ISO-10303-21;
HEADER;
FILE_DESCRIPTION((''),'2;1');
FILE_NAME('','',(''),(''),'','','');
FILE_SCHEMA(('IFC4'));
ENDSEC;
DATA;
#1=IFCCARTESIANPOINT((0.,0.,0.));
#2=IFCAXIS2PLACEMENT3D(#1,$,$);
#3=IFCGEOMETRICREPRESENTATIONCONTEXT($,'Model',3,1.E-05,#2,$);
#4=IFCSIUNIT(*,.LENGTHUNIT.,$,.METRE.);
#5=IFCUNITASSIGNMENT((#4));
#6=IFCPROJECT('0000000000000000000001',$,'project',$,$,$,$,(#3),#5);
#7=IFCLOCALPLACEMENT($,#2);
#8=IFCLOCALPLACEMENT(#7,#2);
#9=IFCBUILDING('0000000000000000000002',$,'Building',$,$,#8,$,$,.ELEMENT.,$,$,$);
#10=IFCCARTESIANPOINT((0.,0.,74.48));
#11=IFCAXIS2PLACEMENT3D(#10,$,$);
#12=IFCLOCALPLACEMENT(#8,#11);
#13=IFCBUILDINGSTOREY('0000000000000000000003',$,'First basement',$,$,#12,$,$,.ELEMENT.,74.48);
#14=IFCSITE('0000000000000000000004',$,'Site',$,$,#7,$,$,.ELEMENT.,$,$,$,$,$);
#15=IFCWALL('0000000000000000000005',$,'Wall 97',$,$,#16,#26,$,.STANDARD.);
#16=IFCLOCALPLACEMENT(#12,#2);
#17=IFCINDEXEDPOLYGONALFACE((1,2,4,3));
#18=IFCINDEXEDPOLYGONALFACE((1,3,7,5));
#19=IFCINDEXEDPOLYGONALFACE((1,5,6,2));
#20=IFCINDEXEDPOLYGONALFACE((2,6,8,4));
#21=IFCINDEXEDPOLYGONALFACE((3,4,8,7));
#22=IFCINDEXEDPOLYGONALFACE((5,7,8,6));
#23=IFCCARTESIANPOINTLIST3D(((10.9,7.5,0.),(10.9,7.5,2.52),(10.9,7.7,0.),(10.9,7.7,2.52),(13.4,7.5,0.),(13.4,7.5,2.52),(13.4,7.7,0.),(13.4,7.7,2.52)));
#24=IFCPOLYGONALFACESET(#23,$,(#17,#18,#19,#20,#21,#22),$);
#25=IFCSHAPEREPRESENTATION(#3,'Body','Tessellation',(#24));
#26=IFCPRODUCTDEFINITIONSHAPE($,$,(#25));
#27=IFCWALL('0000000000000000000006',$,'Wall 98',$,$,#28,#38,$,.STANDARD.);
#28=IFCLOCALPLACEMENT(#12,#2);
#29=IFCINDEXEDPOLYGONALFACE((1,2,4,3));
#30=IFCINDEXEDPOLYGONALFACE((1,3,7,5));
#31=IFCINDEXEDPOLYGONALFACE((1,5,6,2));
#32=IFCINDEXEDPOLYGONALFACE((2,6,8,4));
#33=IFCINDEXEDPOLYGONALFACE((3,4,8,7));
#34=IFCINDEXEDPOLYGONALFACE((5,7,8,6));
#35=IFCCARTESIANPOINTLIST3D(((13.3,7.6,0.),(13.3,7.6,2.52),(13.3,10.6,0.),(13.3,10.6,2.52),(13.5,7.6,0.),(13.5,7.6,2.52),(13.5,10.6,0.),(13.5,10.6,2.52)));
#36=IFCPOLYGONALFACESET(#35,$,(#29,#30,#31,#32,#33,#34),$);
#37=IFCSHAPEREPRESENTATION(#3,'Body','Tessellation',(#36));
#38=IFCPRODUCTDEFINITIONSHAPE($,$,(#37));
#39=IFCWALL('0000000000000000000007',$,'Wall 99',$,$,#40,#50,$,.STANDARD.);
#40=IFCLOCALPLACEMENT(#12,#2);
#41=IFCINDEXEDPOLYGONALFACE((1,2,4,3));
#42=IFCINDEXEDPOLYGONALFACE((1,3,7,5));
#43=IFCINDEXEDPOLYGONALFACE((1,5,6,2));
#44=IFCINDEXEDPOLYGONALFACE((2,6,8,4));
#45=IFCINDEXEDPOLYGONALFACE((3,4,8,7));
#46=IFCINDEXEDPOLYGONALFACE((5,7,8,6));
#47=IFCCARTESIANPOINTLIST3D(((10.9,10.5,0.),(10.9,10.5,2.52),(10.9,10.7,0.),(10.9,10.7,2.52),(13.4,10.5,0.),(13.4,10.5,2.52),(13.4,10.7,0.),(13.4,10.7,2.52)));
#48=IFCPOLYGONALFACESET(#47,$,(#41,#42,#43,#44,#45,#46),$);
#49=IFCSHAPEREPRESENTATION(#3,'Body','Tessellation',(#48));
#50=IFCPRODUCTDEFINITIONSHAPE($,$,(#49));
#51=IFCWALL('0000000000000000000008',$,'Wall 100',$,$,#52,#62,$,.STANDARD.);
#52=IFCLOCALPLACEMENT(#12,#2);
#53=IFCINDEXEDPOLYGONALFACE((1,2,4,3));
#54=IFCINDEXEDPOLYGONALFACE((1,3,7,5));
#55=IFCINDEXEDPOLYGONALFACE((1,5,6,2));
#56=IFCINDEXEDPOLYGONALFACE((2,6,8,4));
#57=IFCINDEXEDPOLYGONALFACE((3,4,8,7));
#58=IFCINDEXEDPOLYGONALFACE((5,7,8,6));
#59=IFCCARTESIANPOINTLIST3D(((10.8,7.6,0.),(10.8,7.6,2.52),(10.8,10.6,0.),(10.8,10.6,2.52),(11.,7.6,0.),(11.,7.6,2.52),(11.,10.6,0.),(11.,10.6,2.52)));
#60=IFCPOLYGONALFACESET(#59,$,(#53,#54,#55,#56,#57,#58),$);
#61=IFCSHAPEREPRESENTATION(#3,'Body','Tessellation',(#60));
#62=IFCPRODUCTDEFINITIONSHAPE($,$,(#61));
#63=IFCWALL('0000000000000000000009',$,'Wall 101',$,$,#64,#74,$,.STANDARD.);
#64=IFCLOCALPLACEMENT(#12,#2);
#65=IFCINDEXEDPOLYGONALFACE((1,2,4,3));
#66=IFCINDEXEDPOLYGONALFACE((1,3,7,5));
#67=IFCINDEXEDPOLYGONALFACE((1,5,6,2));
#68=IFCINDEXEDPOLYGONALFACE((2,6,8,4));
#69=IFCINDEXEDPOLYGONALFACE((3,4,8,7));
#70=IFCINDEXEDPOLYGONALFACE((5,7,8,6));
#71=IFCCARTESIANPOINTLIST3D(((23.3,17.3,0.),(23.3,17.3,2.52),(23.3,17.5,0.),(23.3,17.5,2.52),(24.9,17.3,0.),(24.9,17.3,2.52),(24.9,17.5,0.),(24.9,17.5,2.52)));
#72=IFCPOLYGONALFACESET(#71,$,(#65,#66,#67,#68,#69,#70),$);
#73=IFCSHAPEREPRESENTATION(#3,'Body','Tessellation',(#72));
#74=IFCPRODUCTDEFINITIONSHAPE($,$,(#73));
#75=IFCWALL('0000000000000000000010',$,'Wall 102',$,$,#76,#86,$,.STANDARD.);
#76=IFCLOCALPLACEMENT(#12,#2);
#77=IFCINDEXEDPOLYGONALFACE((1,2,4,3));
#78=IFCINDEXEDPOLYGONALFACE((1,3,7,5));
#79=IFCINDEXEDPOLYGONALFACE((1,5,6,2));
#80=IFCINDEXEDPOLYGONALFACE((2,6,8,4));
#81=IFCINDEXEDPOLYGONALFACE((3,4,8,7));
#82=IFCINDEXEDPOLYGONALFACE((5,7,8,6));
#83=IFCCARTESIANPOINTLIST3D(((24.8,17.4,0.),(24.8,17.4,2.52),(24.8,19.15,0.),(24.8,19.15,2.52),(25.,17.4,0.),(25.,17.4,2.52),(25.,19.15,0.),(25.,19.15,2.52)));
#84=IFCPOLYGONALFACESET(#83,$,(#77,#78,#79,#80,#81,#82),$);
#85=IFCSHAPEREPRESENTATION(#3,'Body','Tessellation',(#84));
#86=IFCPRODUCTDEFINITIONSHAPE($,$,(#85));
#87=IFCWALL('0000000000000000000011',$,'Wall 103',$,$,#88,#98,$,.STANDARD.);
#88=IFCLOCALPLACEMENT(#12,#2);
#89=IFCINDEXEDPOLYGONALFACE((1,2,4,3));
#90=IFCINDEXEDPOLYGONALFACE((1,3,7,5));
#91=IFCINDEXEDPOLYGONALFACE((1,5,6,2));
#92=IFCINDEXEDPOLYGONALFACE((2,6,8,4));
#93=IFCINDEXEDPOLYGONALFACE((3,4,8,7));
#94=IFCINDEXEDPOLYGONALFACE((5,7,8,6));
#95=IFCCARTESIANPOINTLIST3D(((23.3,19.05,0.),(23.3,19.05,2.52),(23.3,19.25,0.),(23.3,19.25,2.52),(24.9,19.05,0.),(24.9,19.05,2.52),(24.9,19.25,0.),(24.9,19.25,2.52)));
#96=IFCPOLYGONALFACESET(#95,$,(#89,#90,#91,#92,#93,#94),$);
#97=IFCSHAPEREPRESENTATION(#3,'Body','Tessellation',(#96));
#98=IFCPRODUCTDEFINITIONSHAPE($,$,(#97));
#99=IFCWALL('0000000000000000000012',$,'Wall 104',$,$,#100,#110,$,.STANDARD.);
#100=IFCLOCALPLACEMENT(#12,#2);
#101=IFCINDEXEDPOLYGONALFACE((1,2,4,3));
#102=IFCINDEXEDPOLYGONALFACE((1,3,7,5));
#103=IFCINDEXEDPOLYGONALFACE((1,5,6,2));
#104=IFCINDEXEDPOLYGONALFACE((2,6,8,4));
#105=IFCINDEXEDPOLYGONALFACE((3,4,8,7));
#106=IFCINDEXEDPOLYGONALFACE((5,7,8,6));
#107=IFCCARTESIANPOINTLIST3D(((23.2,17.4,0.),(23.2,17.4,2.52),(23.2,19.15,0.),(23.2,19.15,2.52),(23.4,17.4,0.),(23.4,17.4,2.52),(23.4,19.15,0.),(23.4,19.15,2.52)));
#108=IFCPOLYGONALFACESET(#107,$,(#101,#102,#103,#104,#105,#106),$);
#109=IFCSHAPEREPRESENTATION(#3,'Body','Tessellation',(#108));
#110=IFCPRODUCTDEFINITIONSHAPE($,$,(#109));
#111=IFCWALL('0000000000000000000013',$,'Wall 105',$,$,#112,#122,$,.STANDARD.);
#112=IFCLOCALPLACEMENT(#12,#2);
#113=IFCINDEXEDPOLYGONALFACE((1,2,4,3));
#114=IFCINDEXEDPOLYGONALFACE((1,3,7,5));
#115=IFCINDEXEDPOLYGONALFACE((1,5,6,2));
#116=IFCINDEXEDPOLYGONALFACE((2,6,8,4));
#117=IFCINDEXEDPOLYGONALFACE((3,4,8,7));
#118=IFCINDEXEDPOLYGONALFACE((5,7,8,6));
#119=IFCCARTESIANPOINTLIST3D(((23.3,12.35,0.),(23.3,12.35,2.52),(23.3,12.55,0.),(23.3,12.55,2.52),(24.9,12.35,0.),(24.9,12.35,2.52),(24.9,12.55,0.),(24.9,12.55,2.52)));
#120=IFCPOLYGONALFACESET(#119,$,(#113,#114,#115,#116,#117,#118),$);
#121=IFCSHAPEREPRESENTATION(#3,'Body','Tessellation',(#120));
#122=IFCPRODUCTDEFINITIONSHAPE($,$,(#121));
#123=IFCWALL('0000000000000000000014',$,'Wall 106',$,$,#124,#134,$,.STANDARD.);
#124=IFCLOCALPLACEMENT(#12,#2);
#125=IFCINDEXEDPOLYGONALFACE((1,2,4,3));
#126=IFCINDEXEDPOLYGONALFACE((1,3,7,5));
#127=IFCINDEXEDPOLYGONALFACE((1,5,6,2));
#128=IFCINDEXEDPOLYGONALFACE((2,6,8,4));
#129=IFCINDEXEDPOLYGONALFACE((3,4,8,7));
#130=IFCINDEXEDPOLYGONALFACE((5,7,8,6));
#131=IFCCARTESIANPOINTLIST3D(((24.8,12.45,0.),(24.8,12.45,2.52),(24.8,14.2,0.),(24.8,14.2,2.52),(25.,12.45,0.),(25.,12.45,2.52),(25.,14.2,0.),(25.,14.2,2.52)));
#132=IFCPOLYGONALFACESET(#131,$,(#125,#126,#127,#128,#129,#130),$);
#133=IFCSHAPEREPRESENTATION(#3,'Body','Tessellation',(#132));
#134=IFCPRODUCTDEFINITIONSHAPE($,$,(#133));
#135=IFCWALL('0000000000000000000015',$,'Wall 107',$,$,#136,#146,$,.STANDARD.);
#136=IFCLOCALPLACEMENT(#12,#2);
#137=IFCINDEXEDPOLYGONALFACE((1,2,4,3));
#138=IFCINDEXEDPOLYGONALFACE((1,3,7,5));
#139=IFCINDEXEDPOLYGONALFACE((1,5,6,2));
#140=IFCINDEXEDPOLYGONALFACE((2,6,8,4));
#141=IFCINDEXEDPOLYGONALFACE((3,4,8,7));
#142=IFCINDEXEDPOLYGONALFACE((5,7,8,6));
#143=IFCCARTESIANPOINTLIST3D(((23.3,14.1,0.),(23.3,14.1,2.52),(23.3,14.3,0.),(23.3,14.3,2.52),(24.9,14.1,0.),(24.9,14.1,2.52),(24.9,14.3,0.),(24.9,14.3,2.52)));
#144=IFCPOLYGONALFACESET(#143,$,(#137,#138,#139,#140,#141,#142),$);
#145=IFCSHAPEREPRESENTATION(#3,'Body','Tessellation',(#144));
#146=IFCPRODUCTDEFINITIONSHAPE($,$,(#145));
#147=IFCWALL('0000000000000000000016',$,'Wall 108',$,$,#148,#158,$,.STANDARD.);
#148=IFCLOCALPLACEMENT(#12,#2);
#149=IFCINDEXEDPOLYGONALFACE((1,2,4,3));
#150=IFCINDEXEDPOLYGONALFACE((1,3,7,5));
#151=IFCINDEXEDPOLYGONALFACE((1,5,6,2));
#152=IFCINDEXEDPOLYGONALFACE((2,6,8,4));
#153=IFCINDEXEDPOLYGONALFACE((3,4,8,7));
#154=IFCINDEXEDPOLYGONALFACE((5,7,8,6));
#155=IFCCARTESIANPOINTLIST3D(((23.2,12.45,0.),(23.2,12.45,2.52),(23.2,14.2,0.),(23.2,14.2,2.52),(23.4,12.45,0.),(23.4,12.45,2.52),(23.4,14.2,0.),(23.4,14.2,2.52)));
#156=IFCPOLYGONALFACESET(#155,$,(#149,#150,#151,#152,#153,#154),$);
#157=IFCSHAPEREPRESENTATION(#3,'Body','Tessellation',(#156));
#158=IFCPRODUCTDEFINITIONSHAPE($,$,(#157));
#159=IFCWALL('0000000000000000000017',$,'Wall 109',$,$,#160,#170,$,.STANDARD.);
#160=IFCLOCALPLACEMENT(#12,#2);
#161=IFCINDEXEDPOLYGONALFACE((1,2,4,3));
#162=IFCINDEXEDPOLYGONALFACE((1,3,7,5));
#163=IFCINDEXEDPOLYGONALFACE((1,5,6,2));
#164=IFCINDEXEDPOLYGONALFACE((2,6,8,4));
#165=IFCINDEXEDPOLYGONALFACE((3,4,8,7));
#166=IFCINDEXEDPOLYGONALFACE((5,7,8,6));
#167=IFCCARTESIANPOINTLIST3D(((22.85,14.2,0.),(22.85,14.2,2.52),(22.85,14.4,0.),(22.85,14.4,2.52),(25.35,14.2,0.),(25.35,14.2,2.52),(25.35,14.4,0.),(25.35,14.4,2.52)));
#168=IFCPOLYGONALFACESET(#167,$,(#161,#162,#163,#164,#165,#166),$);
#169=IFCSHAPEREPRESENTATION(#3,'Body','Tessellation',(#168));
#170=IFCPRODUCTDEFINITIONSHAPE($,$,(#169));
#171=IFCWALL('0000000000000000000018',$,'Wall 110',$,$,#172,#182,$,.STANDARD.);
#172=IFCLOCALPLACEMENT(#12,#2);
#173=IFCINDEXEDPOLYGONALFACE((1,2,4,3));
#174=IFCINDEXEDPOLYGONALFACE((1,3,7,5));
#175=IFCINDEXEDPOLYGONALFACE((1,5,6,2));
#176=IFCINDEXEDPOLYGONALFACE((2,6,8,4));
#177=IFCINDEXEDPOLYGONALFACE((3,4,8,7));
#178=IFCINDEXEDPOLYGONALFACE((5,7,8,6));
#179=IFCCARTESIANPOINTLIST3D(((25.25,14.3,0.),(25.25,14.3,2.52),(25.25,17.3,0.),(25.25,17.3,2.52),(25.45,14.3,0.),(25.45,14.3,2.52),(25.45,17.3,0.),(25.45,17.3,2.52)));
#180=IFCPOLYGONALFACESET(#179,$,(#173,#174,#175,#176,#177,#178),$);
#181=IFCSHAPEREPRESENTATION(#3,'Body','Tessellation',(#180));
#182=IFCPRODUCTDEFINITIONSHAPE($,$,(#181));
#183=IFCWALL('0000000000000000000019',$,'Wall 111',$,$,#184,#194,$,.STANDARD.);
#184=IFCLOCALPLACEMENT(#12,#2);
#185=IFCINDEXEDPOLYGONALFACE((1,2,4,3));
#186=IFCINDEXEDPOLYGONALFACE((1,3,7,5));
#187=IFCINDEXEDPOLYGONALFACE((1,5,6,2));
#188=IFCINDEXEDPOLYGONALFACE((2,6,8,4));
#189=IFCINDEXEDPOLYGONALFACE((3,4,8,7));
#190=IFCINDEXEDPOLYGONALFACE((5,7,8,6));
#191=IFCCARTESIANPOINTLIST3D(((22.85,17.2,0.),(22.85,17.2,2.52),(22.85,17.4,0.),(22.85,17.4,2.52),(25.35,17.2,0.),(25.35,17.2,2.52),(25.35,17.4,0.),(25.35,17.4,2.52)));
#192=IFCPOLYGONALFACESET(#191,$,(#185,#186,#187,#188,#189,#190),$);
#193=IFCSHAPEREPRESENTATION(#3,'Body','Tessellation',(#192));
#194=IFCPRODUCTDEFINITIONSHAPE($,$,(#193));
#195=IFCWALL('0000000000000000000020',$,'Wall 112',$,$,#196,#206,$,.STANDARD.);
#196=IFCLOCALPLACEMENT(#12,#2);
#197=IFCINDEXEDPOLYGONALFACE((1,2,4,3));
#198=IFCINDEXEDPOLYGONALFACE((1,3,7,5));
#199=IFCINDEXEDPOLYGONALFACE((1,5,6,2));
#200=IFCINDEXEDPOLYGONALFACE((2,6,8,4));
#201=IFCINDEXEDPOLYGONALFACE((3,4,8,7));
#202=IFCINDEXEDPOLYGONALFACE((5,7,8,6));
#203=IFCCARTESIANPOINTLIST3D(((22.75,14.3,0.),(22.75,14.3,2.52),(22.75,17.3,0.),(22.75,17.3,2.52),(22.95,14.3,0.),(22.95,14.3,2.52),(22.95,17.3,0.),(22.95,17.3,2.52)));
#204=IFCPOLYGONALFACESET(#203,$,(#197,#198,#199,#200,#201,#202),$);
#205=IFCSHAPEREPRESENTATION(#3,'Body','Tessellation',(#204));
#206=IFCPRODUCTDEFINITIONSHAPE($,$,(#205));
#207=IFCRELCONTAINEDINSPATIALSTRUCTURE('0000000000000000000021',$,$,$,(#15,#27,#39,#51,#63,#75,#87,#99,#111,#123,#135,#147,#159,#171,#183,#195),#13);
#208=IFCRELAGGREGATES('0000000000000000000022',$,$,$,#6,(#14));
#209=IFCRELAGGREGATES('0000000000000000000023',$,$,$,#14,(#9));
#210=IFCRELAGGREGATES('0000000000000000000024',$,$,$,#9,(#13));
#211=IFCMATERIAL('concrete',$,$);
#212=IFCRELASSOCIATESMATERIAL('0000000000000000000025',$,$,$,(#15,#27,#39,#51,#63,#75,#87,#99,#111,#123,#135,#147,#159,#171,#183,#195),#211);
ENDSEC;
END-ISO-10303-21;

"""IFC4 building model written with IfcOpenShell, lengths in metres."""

from ifc_helpers import new_model, si_unit, frame, frame_2d, origin, place, context, project, spatial, rectangle, extrude, material, element, save


model = new_model("IFC4")

# Units and contexts
model_context = context("Model", 3, precision=1e-05, world=origin())
ifc_project = project(units=[si_unit("LENGTHUNIT", "METRE")], contexts=[model_context])

# Site, building, storey
site_placement = place(None, origin())
site = spatial("IfcSite", under=ifc_project, at=site_placement, Name="Site", CompositionType="ELEMENT")
building_placement = place(site_placement, origin())
building = spatial("IfcBuilding", under=site, at=building_placement, Name="Building", CompositionType="ELEMENT")
storey_placement = place(building_placement, frame((0.0, 0.0, 74.48)))
storey = spatial("IfcBuildingStorey", under=building, at=storey_placement, Name="First basement", CompositionType="ELEMENT", Elevation=74.48)

# Shared definitions
ifc_material = material(Name="concrete")

# Walls
wall_1_placement = place(storey_placement, frame((10.9, 7.6, 0.0), z_axis=(0.0, 0.0, 1.0), x_axis=(1.0, 0.0, 0.0)))
element("IfcWall", 1, at=wall_1_placement, inside=storey, material=ifc_material, Name="Wall 97", PredefinedType="STANDARD", context=model_context, shape_type="SweptSolid", body=[
    extrude(rectangle(XDim=2.5, YDim=0.2, at=frame_2d((1.25, 0.0))), origin(), (0.0, 0.0, 1.0), 2.52),
])
wall_2_placement = place(storey_placement, frame((13.4, 7.6, 0.0), z_axis=(0.0, 0.0, 1.0), x_axis=(0.0, 1.0, 0.0)))
element("IfcWall", 2, at=wall_2_placement, inside=storey, material=ifc_material, Name="Wall 98", PredefinedType="STANDARD", context=model_context, shape_type="SweptSolid", body=[
    extrude(rectangle(XDim=3.0, YDim=0.2, at=frame_2d((1.5, 0.0))), origin(), (0.0, 0.0, 1.0), 2.52),
])
wall_3_placement = place(storey_placement, frame((13.4, 10.6, 0.0), z_axis=(0.0, 0.0, 1.0), x_axis=(-1.0, 0.0, 0.0)))
element("IfcWall", 3, at=wall_3_placement, inside=storey, material=ifc_material, Name="Wall 99", PredefinedType="STANDARD", context=model_context, shape_type="SweptSolid", body=[
    extrude(rectangle(XDim=2.5, YDim=0.2, at=frame_2d((1.25, 0.0))), origin(), (0.0, 0.0, 1.0), 2.52),
])
wall_4_placement = place(storey_placement, frame((10.9, 10.6, 0.0), z_axis=(0.0, 0.0, 1.0), x_axis=(0.0, -1.0, 0.0)))
element("IfcWall", 4, at=wall_4_placement, inside=storey, material=ifc_material, Name="Wall 100", PredefinedType="STANDARD", context=model_context, shape_type="SweptSolid", body=[
    extrude(rectangle(XDim=3.0, YDim=0.2, at=frame_2d((1.5, 0.0))), origin(), (0.0, 0.0, 1.0), 2.52),
])
wall_5_placement = place(storey_placement, frame((23.3, 17.4, 0.0), z_axis=(0.0, 0.0, 1.0), x_axis=(1.0, 0.0, 0.0)))
element("IfcWall", 5, at=wall_5_placement, inside=storey, material=ifc_material, Name="Wall 101", PredefinedType="STANDARD", context=model_context, shape_type="SweptSolid", body=[
    extrude(rectangle(XDim=1.6, YDim=0.2, at=frame_2d((0.8, 0.0))), origin(), (0.0, 0.0, 1.0), 2.52),
])
wall_6_placement = place(storey_placement, frame((24.9, 17.4, 0.0), z_axis=(0.0, 0.0, 1.0), x_axis=(0.0, 1.0, 0.0)))
element("IfcWall", 6, at=wall_6_placement, inside=storey, material=ifc_material, Name="Wall 102", PredefinedType="STANDARD", context=model_context, shape_type="SweptSolid", body=[
    extrude(rectangle(XDim=1.75, YDim=0.2, at=frame_2d((0.875, 0.0))), origin(), (0.0, 0.0, 1.0), 2.52),
])
wall_7_placement = place(storey_placement, frame((24.9, 19.15, 0.0), z_axis=(0.0, 0.0, 1.0), x_axis=(-1.0, 0.0, 0.0)))
element("IfcWall", 7, at=wall_7_placement, inside=storey, material=ifc_material, Name="Wall 103", PredefinedType="STANDARD", context=model_context, shape_type="SweptSolid", body=[
    extrude(rectangle(XDim=1.6, YDim=0.2, at=frame_2d((0.8, 0.0))), origin(), (0.0, 0.0, 1.0), 2.52),
])
wall_8_placement = place(storey_placement, frame((23.3, 19.15, 0.0), z_axis=(0.0, 0.0, 1.0), x_axis=(0.0, -1.0, 0.0)))
element("IfcWall", 8, at=wall_8_placement, inside=storey, material=ifc_material, Name="Wall 104", PredefinedType="STANDARD", context=model_context, shape_type="SweptSolid", body=[
    extrude(rectangle(XDim=1.75, YDim=0.2, at=frame_2d((0.875, 0.0))), origin(), (0.0, 0.0, 1.0), 2.52),
])
wall_9_placement = place(storey_placement, frame((23.3, 12.45, 0.0), z_axis=(0.0, 0.0, 1.0), x_axis=(1.0, 0.0, 0.0)))
element("IfcWall", 9, at=wall_9_placement, inside=storey, material=ifc_material, Name="Wall 105", PredefinedType="STANDARD", context=model_context, shape_type="SweptSolid", body=[
    extrude(rectangle(XDim=1.6, YDim=0.2, at=frame_2d((0.8, 0.0))), origin(), (0.0, 0.0, 1.0), 2.52),
])
wall_10_placement = place(storey_placement, frame((24.9, 12.45, 0.0), z_axis=(0.0, 0.0, 1.0), x_axis=(0.0, 1.0, 0.0)))
element("IfcWall", 10, at=wall_10_placement, inside=storey, material=ifc_material, Name="Wall 106", PredefinedType="STANDARD", context=model_context, shape_type="SweptSolid", body=[
    extrude(rectangle(XDim=1.75, YDim=0.2, at=frame_2d((0.875, 0.0))), origin(), (0.0, 0.0, 1.0), 2.52),
])
wall_11_placement = place(storey_placement, frame((24.9, 14.2, 0.0), z_axis=(0.0, 0.0, 1.0), x_axis=(-1.0, 0.0, 0.0)))
element("IfcWall", 11, at=wall_11_placement, inside=storey, material=ifc_material, Name="Wall 107", PredefinedType="STANDARD", context=model_context, shape_type="SweptSolid", body=[
    extrude(rectangle(XDim=1.6, YDim=0.2, at=frame_2d((0.8, 0.0))), origin(), (0.0, 0.0, 1.0), 2.52),
])
wall_12_placement = place(storey_placement, frame((23.3, 14.2, 0.0), z_axis=(0.0, 0.0, 1.0), x_axis=(0.0, -1.0, 0.0)))
element("IfcWall", 12, at=wall_12_placement, inside=storey, material=ifc_material, Name="Wall 108", PredefinedType="STANDARD", context=model_context, shape_type="SweptSolid", body=[
    extrude(rectangle(XDim=1.75, YDim=0.2, at=frame_2d((0.875, 0.0))), origin(), (0.0, 0.0, 1.0), 2.52),
])
wall_13_placement = place(storey_placement, frame((22.85, 14.3, 0.0), z_axis=(0.0, 0.0, 1.0), x_axis=(1.0, 0.0, 0.0)))
element("IfcWall", 13, at=wall_13_placement, inside=storey, material=ifc_material, Name="Wall 109", PredefinedType="STANDARD", context=model_context, shape_type="SweptSolid", body=[
    extrude(rectangle(XDim=2.5, YDim=0.2, at=frame_2d((1.25, 0.0))), origin(), (0.0, 0.0, 1.0), 2.52),
])
wall_14_placement = place(storey_placement, frame((25.35, 14.3, 0.0), z_axis=(0.0, 0.0, 1.0), x_axis=(0.0, 1.0, 0.0)))
element("IfcWall", 14, at=wall_14_placement, inside=storey, material=ifc_material, Name="Wall 110", PredefinedType="STANDARD", context=model_context, shape_type="SweptSolid", body=[
    extrude(rectangle(XDim=3.0, YDim=0.2, at=frame_2d((1.5, 0.0))), origin(), (0.0, 0.0, 1.0), 2.52),
])
wall_15_placement = place(storey_placement, frame((25.35, 17.3, 0.0), z_axis=(0.0, 0.0, 1.0), x_axis=(-1.0, 0.0, 0.0)))
element("IfcWall", 15, at=wall_15_placement, inside=storey, material=ifc_material, Name="Wall 111", PredefinedType="STANDARD", context=model_context, shape_type="SweptSolid", body=[
    extrude(rectangle(XDim=2.5, YDim=0.2, at=frame_2d((1.25, 0.0))), origin(), (0.0, 0.0, 1.0), 2.52),
])
wall_16_placement = place(storey_placement, frame((22.85, 17.3, 0.0), z_axis=(0.0, 0.0, 1.0), x_axis=(0.0, -1.0, 0.0)))
element("IfcWall", 16, at=wall_16_placement, inside=storey, material=ifc_material, Name="Wall 112", PredefinedType="STANDARD", context=model_context, shape_type="SweptSolid", body=[
    extrude(rectangle(XDim=3.0, YDim=0.2, at=frame_2d((1.5, 0.0))), origin(), (0.0, 0.0, 1.0), 2.52),
])

save(model, "model.ifc")
